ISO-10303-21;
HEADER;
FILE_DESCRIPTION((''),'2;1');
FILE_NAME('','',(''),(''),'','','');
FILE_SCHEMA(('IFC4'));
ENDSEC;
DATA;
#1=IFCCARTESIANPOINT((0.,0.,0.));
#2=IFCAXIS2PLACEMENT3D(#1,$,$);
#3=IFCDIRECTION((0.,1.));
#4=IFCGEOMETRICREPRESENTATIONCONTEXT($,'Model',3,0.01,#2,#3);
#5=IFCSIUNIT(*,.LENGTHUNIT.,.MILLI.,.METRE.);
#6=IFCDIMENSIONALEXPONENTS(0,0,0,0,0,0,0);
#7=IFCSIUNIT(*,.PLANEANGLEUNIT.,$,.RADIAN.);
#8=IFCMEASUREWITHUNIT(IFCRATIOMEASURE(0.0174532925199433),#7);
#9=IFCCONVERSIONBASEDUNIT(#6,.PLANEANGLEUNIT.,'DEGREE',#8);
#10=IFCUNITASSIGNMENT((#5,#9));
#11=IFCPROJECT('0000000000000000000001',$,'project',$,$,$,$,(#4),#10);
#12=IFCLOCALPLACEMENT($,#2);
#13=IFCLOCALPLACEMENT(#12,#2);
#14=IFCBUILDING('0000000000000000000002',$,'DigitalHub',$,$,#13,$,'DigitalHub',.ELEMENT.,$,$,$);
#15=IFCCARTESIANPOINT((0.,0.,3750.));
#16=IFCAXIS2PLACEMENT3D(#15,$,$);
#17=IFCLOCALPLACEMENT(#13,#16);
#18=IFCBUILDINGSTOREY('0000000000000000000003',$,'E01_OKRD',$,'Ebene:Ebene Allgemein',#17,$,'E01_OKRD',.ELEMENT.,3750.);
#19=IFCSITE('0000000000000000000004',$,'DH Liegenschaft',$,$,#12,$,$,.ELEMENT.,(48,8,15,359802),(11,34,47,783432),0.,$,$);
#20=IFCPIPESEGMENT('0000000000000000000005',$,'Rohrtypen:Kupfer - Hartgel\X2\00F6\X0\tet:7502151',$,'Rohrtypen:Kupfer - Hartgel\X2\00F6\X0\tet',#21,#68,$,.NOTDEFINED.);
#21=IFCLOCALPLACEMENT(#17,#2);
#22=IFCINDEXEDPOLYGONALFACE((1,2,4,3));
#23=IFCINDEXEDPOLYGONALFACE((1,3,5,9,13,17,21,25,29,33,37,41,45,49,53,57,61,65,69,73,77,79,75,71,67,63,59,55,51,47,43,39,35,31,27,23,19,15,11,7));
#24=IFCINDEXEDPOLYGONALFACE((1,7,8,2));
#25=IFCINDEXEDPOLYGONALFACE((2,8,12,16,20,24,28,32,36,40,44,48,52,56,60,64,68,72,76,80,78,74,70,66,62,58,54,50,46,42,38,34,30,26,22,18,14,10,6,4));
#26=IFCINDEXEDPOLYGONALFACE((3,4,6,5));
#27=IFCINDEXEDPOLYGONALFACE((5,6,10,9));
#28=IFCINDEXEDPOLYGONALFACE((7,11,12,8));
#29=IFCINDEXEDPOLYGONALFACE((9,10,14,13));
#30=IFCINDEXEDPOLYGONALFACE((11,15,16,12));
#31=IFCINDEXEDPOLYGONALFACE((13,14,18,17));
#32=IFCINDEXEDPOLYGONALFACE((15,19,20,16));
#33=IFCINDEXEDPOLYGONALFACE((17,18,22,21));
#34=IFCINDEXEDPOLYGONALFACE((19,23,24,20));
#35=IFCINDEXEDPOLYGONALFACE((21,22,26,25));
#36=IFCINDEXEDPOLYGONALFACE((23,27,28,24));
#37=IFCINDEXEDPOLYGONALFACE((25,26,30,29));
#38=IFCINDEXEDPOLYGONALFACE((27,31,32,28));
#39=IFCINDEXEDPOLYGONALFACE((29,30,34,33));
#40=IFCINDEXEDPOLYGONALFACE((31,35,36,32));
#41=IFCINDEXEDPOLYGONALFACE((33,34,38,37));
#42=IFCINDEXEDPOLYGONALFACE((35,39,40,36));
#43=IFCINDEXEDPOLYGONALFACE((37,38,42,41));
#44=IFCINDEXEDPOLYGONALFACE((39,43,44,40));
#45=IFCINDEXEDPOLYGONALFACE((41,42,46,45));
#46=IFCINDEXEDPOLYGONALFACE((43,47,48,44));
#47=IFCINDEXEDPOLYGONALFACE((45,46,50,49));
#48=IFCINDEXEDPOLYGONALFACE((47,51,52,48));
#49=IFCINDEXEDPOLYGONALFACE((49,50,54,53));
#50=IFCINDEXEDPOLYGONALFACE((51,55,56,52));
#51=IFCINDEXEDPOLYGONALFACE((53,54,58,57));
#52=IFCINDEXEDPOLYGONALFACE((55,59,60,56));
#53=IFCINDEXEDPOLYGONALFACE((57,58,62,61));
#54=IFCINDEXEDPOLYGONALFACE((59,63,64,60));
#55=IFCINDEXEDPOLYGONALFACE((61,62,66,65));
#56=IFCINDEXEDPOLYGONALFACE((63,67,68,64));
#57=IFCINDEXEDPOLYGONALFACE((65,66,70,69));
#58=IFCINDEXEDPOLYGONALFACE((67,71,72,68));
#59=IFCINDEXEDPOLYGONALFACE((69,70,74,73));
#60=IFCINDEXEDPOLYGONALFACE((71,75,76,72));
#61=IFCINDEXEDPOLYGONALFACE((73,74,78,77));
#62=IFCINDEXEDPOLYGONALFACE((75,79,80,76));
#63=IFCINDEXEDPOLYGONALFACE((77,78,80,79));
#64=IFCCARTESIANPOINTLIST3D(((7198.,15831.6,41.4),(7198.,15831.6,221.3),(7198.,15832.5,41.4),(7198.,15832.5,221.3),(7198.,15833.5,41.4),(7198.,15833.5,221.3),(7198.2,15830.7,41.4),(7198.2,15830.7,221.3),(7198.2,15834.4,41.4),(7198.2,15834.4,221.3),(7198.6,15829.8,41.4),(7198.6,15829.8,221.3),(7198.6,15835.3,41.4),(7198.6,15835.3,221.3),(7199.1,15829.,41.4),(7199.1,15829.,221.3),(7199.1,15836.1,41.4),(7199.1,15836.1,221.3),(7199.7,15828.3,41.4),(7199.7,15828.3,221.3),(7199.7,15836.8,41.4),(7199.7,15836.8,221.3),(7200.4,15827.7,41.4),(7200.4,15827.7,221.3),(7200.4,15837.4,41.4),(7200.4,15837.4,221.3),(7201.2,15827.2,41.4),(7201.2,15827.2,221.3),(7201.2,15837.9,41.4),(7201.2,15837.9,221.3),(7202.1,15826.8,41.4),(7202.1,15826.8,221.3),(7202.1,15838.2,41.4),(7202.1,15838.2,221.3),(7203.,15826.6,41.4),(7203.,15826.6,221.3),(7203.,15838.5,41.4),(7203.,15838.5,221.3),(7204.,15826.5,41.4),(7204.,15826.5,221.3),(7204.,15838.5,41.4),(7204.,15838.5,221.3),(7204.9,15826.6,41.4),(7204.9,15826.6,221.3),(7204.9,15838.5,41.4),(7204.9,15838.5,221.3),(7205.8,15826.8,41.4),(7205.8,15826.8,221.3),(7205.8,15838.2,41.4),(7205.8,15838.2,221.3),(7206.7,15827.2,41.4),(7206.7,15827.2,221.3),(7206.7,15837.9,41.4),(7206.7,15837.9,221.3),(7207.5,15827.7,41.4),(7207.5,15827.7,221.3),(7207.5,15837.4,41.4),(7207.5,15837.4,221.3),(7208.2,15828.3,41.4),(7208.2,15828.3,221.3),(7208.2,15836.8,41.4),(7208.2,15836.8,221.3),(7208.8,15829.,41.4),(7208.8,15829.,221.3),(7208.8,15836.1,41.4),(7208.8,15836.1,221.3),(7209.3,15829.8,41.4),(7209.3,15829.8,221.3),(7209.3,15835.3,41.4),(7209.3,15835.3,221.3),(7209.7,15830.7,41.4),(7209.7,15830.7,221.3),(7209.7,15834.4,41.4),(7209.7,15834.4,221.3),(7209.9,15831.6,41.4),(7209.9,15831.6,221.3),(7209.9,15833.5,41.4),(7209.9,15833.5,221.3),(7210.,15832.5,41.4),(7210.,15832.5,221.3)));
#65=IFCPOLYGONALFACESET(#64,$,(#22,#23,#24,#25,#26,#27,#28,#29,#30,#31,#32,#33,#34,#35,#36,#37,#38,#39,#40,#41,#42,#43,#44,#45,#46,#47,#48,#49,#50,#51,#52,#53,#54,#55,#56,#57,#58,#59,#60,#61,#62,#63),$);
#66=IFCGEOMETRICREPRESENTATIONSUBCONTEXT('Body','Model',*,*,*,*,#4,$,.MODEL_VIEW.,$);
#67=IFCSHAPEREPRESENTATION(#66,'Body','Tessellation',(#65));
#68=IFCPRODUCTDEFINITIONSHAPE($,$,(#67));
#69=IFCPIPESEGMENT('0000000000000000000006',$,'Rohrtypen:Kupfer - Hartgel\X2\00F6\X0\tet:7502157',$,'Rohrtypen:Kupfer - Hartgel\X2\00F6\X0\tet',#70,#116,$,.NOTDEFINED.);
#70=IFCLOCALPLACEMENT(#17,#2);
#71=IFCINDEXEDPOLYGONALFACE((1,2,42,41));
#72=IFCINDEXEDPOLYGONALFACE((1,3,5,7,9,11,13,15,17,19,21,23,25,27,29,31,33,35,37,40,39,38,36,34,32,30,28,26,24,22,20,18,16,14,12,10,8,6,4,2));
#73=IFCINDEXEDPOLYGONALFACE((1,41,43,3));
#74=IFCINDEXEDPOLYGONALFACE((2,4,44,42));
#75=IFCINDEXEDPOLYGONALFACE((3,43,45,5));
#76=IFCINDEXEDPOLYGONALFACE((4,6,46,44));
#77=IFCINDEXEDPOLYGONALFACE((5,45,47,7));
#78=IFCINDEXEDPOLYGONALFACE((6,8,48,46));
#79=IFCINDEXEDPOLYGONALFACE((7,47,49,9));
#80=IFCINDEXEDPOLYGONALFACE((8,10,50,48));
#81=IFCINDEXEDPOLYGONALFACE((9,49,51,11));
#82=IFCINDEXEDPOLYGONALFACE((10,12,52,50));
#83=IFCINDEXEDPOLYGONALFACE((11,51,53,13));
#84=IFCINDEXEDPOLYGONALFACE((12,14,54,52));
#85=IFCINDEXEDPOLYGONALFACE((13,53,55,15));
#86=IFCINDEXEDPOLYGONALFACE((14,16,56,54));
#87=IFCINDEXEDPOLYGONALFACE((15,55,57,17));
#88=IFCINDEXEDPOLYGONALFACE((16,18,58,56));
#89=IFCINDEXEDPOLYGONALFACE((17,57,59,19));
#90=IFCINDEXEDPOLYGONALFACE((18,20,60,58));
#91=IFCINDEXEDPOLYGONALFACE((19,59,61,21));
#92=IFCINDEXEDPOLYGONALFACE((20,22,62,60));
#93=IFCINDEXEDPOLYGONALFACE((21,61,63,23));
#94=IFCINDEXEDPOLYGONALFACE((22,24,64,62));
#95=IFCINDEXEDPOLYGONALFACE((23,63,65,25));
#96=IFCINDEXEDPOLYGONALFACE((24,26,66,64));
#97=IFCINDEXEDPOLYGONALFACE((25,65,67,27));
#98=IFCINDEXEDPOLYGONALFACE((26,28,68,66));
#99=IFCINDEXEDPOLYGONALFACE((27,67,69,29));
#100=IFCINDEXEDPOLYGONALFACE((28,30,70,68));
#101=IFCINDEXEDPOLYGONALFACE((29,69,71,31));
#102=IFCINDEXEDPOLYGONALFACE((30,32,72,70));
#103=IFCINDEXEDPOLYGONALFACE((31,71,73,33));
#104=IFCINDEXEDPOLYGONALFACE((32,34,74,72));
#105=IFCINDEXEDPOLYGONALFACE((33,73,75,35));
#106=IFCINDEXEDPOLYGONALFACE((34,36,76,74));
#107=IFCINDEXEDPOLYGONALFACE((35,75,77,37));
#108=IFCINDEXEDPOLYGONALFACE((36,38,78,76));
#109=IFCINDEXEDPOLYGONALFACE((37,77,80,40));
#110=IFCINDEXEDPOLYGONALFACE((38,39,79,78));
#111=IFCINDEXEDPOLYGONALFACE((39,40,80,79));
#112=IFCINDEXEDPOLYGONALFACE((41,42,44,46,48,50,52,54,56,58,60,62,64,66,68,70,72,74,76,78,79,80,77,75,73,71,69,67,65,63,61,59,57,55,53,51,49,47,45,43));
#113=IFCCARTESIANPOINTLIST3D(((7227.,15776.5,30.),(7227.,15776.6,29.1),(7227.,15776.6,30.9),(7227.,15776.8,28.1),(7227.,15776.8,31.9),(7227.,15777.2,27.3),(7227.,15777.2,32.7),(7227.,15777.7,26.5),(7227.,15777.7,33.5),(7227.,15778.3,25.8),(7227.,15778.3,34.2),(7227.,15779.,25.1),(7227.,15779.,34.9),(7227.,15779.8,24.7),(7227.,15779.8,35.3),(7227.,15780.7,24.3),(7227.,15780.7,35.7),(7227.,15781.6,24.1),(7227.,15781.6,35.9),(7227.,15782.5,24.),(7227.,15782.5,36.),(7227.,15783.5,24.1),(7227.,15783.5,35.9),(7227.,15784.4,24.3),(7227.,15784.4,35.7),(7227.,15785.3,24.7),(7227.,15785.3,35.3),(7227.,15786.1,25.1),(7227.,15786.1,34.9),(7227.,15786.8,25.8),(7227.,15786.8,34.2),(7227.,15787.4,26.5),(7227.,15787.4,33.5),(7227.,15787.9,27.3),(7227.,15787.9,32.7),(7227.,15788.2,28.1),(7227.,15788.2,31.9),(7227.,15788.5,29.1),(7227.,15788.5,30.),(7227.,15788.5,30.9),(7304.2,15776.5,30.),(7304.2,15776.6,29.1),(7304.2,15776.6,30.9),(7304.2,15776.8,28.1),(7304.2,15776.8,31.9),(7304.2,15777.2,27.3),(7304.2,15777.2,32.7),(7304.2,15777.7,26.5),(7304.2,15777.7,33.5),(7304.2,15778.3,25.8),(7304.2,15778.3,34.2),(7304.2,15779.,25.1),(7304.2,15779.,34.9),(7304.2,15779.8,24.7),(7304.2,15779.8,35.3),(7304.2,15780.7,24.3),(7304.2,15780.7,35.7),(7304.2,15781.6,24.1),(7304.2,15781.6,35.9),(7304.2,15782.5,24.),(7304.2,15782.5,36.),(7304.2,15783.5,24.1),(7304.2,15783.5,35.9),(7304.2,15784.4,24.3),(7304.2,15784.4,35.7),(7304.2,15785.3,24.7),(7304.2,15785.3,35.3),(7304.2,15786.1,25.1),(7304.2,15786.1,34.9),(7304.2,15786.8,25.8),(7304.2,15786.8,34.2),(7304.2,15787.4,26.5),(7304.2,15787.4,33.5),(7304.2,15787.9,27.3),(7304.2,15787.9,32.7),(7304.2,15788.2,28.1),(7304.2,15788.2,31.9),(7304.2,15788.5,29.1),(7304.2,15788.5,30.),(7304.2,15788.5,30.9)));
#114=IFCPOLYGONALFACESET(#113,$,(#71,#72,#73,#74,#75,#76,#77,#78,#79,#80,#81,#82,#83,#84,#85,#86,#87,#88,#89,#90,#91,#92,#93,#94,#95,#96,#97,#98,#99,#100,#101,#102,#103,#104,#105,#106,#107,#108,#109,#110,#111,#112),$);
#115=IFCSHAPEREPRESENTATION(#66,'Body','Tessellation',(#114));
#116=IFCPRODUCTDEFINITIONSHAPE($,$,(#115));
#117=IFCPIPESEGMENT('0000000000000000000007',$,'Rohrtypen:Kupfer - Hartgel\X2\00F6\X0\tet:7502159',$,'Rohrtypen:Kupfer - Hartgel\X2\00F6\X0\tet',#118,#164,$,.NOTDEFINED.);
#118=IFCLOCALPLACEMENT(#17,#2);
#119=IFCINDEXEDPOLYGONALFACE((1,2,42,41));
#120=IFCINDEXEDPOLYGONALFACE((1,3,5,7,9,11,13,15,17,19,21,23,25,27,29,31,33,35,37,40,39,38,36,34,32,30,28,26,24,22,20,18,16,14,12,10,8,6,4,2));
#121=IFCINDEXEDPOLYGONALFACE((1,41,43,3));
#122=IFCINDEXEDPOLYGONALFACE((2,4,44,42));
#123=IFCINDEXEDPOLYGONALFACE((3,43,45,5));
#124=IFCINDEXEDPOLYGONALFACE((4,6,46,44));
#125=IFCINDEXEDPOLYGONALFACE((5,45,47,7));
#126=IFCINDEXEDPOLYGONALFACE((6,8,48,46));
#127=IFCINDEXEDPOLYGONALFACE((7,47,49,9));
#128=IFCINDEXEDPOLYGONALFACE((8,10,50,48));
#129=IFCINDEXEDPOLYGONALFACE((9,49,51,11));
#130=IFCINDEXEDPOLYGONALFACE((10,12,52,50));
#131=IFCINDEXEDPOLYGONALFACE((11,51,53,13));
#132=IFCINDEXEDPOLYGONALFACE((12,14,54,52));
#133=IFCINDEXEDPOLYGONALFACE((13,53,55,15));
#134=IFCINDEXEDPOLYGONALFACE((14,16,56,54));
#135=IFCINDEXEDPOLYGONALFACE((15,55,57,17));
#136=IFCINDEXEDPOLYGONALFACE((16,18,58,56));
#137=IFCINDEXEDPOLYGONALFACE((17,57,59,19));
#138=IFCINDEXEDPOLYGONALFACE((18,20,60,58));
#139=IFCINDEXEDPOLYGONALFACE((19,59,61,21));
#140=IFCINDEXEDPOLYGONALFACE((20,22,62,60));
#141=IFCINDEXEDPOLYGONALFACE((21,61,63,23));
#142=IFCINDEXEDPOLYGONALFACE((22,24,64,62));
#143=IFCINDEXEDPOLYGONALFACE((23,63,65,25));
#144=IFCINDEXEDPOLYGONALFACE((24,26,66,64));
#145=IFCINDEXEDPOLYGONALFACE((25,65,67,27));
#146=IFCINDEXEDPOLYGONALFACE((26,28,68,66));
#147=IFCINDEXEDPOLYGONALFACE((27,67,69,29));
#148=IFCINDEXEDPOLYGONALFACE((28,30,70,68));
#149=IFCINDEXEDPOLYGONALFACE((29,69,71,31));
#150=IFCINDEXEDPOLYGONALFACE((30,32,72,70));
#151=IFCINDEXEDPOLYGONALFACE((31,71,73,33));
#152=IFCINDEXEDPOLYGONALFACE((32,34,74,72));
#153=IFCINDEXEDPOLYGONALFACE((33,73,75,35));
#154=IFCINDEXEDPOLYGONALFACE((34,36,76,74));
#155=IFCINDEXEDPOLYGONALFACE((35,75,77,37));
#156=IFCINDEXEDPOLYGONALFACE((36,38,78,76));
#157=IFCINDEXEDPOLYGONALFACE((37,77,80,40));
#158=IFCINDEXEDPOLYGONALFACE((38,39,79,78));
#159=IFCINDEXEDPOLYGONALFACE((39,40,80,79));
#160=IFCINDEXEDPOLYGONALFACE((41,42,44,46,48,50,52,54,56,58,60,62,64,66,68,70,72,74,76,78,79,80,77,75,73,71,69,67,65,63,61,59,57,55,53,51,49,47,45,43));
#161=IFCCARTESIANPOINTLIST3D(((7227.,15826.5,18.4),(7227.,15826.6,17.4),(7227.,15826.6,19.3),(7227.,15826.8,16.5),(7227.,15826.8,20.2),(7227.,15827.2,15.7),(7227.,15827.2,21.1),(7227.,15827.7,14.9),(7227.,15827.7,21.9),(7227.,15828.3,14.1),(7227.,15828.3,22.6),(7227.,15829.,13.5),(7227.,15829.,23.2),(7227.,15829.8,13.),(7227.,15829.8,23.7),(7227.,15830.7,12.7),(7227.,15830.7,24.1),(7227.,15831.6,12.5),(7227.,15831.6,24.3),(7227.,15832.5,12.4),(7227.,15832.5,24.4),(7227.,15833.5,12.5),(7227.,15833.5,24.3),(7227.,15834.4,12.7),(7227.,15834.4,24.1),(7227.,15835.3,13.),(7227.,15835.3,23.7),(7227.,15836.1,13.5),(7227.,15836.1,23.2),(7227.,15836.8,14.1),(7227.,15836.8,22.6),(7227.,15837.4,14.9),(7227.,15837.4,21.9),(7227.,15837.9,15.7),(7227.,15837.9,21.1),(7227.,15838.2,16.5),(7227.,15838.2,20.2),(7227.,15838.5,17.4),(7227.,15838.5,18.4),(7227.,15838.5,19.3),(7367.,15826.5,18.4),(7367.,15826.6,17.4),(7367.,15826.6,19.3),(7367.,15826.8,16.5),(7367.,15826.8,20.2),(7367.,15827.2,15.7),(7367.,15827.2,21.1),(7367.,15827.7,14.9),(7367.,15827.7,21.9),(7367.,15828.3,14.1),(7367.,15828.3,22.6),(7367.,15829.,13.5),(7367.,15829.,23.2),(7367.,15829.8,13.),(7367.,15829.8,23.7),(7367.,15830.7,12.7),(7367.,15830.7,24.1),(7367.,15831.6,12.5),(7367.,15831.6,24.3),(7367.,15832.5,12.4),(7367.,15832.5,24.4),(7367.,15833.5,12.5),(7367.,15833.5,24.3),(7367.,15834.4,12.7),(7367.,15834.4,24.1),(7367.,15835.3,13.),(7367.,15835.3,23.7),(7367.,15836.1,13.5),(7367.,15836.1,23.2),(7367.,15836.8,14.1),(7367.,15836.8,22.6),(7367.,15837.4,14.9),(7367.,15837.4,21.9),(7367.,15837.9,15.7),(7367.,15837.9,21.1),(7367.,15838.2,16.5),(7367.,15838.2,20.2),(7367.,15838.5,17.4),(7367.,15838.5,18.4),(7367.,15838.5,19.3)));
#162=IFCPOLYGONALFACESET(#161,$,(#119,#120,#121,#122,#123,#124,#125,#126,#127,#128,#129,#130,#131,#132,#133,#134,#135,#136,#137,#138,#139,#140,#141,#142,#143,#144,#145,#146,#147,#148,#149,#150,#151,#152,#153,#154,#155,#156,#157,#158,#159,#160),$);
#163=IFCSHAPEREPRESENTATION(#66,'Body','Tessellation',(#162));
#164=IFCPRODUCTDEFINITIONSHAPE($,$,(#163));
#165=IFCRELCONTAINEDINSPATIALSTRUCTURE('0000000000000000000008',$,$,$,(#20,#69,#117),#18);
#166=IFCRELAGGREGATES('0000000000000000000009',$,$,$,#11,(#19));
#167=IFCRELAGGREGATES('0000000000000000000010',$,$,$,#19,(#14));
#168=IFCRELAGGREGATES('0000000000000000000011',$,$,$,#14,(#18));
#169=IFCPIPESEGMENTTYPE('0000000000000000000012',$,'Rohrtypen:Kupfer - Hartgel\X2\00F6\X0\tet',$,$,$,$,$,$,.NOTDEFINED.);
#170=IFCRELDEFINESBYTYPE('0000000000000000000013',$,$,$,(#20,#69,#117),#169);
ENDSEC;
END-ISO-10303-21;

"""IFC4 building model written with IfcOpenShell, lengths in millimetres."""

from ifc_helpers import new_model, entity, si_unit, converted_unit, direction, frame, origin, place, context, subcontext, project, spatial, indexed_curve, outline, extrude, type_object, element, save


model = new_model("IFC4")

# Units and contexts
model_context = context("Model", 3, precision=0.01, world=origin(), true_north=direction((0.0, 1.0)))
body_context = subcontext(model_context, "Body", "Model", "MODEL_VIEW")
ifc_project = project(units=[si_unit("LENGTHUNIT", "METRE", prefix="MILLI"), converted_unit("PLANEANGLEUNIT", "DEGREE", entity("IfcRatioMeasure", 0.0174532925199433), si_unit("PLANEANGLEUNIT", "RADIAN"), dimensions=[0, 0, 0, 0, 0, 0, 0])], contexts=[model_context])

# Site, building, storey
site_placement = place(None, origin())
site = spatial("IfcSite", under=ifc_project, at=site_placement, Name="DH Liegenschaft", CompositionType="ELEMENT", RefLatitude=(48, 8, 15, 359802), RefLongitude=(11, 34, 47, 783432), RefElevation=0.0)
building_placement = place(site_placement, origin())
building = spatial("IfcBuilding", under=site, at=building_placement, Name="DigitalHub", LongName="DigitalHub", CompositionType="ELEMENT")
storey_placement = place(building_placement, frame((0.0, 0.0, 3750.0)))
storey = spatial("IfcBuildingStorey", under=building, at=storey_placement, Name="E01_OKRD", ObjectType="Ebene:Ebene Allgemein", LongName="E01_OKRD", CompositionType="ELEMENT", Elevation=3750.0)

# Pipe segments
pipe_segment_type = type_object("IfcPipeSegmentType", Name="Rohrtypen:Kupfer - Hartgelötet", PredefinedType="NOTDEFINED")
pipe_segment_1_placement = place(storey_placement, frame((7196.4, 15824.9, 41.4)))
element("IfcPipeSegment", 1, at=pipe_segment_1_placement, inside=storey, type_object=pipe_segment_type, Name="Rohrtypen:Kupfer - Hartgelötet:7502151", ObjectType="Rohrtypen:Kupfer - Hartgelötet", PredefinedType="NOTDEFINED", context=body_context, shape_type="SweptSolid", body=[
    extrude(outline(indexed_curve([(6.0, 0.0), (5.9, 0.9), (5.7, 1.9), (5.3, 2.7), (4.9, 3.5), (4.2, 4.2), (3.5, 4.9), (2.7, 5.3), (1.9, 5.7), (0.9, 5.9), (0.0, 6.0), (-0.9, 5.9), (-1.9, 5.7), (-2.7, 5.3), (-3.5, 4.9), (-4.2, 4.2), (-4.9, 3.5), (-5.3, 2.7), (-5.7, 1.9), (-5.9, 0.9), (-6.0, 0.0), (-5.9, -0.9), (-5.7, -1.9), (-5.3, -2.7), (-4.9, -3.5), (-4.2, -4.2), (-3.5, -4.9), (-2.7, -5.3), (-1.9, -5.7), (-0.9, -5.9), (0.0, -6.0), (0.9, -5.9), (1.9, -5.7), (2.7, -5.3), (3.5, -4.9), (4.2, -4.2), (4.9, -3.5), (5.3, -2.7), (5.7, -1.9), (5.9, -0.9), (6.0, 0.0)], self_intersect=False)), frame((7.6, 7.6, 0.0)), (0.0, 0.0, 1.0), 179.9),
])
pipe_segment_2_placement = place(storey_placement, frame((7227.0, 15774.9, 22.4)))
element("IfcPipeSegment", 2, at=pipe_segment_2_placement, inside=storey, type_object=pipe_segment_type, Name="Rohrtypen:Kupfer - Hartgelötet:7502157", ObjectType="Rohrtypen:Kupfer - Hartgelötet", PredefinedType="NOTDEFINED", context=body_context, shape_type="SweptSolid", body=[
    extrude(outline(indexed_curve([(6.0, 0.0), (5.9, 0.9), (5.7, 1.9), (5.3, 2.7), (4.9, 3.5), (4.2, 4.2), (3.5, 4.9), (2.7, 5.3), (1.9, 5.7), (0.9, 5.9), (0.0, 6.0), (-0.9, 5.9), (-1.9, 5.7), (-2.7, 5.3), (-3.5, 4.9), (-4.2, 4.2), (-4.9, 3.5), (-5.3, 2.7), (-5.7, 1.9), (-5.9, 0.9), (-6.0, 0.0), (-5.9, -0.9), (-5.7, -1.9), (-5.3, -2.7), (-4.9, -3.5), (-4.2, -4.2), (-3.5, -4.9), (-2.7, -5.3), (-1.9, -5.7), (-0.9, -5.9), (0.0, -6.0), (0.9, -5.9), (1.9, -5.7), (2.7, -5.3), (3.5, -4.9), (4.2, -4.2), (4.9, -3.5), (5.3, -2.7), (5.7, -1.9), (5.9, -0.9), (6.0, 0.0)], self_intersect=False)), frame((0.0, 7.6, 7.6), z_axis=(1.0, 0.0, 0.0), x_axis=(0.0, -1.0, 0.0)), (0.0, 0.0, 1.0), 77.2),
])
pipe_segment_3_placement = place(storey_placement, frame((7227.0, 15824.9, 10.8)))
element("IfcPipeSegment", 3, at=pipe_segment_3_placement, inside=storey, type_object=pipe_segment_type, Name="Rohrtypen:Kupfer - Hartgelötet:7502159", ObjectType="Rohrtypen:Kupfer - Hartgelötet", PredefinedType="NOTDEFINED", context=body_context, shape_type="SweptSolid", body=[
    extrude(outline(indexed_curve([(6.0, 0.0), (5.9, 0.9), (5.7, 1.9), (5.3, 2.7), (4.9, 3.5), (4.2, 4.2), (3.5, 4.9), (2.7, 5.3), (1.9, 5.7), (0.9, 5.9), (0.0, 6.0), (-0.9, 5.9), (-1.9, 5.7), (-2.7, 5.3), (-3.5, 4.9), (-4.2, 4.2), (-4.9, 3.5), (-5.3, 2.7), (-5.7, 1.9), (-5.9, 0.9), (-6.0, 0.0), (-5.9, -0.9), (-5.7, -1.9), (-5.3, -2.7), (-4.9, -3.5), (-4.2, -4.2), (-3.5, -4.9), (-2.7, -5.3), (-1.9, -5.7), (-0.9, -5.9), (0.0, -6.0), (0.9, -5.9), (1.9, -5.7), (2.7, -5.3), (3.5, -4.9), (4.2, -4.2), (4.9, -3.5), (5.3, -2.7), (5.7, -1.9), (5.9, -0.9), (6.0, 0.0)], self_intersect=False)), frame((0.0, 7.6, 7.6), z_axis=(1.0, 0.0, 0.0), x_axis=(0.0, -1.0, 0.0)), (0.0, 0.0, 1.0), 140.0),
])

save(model, "model.ifc")
